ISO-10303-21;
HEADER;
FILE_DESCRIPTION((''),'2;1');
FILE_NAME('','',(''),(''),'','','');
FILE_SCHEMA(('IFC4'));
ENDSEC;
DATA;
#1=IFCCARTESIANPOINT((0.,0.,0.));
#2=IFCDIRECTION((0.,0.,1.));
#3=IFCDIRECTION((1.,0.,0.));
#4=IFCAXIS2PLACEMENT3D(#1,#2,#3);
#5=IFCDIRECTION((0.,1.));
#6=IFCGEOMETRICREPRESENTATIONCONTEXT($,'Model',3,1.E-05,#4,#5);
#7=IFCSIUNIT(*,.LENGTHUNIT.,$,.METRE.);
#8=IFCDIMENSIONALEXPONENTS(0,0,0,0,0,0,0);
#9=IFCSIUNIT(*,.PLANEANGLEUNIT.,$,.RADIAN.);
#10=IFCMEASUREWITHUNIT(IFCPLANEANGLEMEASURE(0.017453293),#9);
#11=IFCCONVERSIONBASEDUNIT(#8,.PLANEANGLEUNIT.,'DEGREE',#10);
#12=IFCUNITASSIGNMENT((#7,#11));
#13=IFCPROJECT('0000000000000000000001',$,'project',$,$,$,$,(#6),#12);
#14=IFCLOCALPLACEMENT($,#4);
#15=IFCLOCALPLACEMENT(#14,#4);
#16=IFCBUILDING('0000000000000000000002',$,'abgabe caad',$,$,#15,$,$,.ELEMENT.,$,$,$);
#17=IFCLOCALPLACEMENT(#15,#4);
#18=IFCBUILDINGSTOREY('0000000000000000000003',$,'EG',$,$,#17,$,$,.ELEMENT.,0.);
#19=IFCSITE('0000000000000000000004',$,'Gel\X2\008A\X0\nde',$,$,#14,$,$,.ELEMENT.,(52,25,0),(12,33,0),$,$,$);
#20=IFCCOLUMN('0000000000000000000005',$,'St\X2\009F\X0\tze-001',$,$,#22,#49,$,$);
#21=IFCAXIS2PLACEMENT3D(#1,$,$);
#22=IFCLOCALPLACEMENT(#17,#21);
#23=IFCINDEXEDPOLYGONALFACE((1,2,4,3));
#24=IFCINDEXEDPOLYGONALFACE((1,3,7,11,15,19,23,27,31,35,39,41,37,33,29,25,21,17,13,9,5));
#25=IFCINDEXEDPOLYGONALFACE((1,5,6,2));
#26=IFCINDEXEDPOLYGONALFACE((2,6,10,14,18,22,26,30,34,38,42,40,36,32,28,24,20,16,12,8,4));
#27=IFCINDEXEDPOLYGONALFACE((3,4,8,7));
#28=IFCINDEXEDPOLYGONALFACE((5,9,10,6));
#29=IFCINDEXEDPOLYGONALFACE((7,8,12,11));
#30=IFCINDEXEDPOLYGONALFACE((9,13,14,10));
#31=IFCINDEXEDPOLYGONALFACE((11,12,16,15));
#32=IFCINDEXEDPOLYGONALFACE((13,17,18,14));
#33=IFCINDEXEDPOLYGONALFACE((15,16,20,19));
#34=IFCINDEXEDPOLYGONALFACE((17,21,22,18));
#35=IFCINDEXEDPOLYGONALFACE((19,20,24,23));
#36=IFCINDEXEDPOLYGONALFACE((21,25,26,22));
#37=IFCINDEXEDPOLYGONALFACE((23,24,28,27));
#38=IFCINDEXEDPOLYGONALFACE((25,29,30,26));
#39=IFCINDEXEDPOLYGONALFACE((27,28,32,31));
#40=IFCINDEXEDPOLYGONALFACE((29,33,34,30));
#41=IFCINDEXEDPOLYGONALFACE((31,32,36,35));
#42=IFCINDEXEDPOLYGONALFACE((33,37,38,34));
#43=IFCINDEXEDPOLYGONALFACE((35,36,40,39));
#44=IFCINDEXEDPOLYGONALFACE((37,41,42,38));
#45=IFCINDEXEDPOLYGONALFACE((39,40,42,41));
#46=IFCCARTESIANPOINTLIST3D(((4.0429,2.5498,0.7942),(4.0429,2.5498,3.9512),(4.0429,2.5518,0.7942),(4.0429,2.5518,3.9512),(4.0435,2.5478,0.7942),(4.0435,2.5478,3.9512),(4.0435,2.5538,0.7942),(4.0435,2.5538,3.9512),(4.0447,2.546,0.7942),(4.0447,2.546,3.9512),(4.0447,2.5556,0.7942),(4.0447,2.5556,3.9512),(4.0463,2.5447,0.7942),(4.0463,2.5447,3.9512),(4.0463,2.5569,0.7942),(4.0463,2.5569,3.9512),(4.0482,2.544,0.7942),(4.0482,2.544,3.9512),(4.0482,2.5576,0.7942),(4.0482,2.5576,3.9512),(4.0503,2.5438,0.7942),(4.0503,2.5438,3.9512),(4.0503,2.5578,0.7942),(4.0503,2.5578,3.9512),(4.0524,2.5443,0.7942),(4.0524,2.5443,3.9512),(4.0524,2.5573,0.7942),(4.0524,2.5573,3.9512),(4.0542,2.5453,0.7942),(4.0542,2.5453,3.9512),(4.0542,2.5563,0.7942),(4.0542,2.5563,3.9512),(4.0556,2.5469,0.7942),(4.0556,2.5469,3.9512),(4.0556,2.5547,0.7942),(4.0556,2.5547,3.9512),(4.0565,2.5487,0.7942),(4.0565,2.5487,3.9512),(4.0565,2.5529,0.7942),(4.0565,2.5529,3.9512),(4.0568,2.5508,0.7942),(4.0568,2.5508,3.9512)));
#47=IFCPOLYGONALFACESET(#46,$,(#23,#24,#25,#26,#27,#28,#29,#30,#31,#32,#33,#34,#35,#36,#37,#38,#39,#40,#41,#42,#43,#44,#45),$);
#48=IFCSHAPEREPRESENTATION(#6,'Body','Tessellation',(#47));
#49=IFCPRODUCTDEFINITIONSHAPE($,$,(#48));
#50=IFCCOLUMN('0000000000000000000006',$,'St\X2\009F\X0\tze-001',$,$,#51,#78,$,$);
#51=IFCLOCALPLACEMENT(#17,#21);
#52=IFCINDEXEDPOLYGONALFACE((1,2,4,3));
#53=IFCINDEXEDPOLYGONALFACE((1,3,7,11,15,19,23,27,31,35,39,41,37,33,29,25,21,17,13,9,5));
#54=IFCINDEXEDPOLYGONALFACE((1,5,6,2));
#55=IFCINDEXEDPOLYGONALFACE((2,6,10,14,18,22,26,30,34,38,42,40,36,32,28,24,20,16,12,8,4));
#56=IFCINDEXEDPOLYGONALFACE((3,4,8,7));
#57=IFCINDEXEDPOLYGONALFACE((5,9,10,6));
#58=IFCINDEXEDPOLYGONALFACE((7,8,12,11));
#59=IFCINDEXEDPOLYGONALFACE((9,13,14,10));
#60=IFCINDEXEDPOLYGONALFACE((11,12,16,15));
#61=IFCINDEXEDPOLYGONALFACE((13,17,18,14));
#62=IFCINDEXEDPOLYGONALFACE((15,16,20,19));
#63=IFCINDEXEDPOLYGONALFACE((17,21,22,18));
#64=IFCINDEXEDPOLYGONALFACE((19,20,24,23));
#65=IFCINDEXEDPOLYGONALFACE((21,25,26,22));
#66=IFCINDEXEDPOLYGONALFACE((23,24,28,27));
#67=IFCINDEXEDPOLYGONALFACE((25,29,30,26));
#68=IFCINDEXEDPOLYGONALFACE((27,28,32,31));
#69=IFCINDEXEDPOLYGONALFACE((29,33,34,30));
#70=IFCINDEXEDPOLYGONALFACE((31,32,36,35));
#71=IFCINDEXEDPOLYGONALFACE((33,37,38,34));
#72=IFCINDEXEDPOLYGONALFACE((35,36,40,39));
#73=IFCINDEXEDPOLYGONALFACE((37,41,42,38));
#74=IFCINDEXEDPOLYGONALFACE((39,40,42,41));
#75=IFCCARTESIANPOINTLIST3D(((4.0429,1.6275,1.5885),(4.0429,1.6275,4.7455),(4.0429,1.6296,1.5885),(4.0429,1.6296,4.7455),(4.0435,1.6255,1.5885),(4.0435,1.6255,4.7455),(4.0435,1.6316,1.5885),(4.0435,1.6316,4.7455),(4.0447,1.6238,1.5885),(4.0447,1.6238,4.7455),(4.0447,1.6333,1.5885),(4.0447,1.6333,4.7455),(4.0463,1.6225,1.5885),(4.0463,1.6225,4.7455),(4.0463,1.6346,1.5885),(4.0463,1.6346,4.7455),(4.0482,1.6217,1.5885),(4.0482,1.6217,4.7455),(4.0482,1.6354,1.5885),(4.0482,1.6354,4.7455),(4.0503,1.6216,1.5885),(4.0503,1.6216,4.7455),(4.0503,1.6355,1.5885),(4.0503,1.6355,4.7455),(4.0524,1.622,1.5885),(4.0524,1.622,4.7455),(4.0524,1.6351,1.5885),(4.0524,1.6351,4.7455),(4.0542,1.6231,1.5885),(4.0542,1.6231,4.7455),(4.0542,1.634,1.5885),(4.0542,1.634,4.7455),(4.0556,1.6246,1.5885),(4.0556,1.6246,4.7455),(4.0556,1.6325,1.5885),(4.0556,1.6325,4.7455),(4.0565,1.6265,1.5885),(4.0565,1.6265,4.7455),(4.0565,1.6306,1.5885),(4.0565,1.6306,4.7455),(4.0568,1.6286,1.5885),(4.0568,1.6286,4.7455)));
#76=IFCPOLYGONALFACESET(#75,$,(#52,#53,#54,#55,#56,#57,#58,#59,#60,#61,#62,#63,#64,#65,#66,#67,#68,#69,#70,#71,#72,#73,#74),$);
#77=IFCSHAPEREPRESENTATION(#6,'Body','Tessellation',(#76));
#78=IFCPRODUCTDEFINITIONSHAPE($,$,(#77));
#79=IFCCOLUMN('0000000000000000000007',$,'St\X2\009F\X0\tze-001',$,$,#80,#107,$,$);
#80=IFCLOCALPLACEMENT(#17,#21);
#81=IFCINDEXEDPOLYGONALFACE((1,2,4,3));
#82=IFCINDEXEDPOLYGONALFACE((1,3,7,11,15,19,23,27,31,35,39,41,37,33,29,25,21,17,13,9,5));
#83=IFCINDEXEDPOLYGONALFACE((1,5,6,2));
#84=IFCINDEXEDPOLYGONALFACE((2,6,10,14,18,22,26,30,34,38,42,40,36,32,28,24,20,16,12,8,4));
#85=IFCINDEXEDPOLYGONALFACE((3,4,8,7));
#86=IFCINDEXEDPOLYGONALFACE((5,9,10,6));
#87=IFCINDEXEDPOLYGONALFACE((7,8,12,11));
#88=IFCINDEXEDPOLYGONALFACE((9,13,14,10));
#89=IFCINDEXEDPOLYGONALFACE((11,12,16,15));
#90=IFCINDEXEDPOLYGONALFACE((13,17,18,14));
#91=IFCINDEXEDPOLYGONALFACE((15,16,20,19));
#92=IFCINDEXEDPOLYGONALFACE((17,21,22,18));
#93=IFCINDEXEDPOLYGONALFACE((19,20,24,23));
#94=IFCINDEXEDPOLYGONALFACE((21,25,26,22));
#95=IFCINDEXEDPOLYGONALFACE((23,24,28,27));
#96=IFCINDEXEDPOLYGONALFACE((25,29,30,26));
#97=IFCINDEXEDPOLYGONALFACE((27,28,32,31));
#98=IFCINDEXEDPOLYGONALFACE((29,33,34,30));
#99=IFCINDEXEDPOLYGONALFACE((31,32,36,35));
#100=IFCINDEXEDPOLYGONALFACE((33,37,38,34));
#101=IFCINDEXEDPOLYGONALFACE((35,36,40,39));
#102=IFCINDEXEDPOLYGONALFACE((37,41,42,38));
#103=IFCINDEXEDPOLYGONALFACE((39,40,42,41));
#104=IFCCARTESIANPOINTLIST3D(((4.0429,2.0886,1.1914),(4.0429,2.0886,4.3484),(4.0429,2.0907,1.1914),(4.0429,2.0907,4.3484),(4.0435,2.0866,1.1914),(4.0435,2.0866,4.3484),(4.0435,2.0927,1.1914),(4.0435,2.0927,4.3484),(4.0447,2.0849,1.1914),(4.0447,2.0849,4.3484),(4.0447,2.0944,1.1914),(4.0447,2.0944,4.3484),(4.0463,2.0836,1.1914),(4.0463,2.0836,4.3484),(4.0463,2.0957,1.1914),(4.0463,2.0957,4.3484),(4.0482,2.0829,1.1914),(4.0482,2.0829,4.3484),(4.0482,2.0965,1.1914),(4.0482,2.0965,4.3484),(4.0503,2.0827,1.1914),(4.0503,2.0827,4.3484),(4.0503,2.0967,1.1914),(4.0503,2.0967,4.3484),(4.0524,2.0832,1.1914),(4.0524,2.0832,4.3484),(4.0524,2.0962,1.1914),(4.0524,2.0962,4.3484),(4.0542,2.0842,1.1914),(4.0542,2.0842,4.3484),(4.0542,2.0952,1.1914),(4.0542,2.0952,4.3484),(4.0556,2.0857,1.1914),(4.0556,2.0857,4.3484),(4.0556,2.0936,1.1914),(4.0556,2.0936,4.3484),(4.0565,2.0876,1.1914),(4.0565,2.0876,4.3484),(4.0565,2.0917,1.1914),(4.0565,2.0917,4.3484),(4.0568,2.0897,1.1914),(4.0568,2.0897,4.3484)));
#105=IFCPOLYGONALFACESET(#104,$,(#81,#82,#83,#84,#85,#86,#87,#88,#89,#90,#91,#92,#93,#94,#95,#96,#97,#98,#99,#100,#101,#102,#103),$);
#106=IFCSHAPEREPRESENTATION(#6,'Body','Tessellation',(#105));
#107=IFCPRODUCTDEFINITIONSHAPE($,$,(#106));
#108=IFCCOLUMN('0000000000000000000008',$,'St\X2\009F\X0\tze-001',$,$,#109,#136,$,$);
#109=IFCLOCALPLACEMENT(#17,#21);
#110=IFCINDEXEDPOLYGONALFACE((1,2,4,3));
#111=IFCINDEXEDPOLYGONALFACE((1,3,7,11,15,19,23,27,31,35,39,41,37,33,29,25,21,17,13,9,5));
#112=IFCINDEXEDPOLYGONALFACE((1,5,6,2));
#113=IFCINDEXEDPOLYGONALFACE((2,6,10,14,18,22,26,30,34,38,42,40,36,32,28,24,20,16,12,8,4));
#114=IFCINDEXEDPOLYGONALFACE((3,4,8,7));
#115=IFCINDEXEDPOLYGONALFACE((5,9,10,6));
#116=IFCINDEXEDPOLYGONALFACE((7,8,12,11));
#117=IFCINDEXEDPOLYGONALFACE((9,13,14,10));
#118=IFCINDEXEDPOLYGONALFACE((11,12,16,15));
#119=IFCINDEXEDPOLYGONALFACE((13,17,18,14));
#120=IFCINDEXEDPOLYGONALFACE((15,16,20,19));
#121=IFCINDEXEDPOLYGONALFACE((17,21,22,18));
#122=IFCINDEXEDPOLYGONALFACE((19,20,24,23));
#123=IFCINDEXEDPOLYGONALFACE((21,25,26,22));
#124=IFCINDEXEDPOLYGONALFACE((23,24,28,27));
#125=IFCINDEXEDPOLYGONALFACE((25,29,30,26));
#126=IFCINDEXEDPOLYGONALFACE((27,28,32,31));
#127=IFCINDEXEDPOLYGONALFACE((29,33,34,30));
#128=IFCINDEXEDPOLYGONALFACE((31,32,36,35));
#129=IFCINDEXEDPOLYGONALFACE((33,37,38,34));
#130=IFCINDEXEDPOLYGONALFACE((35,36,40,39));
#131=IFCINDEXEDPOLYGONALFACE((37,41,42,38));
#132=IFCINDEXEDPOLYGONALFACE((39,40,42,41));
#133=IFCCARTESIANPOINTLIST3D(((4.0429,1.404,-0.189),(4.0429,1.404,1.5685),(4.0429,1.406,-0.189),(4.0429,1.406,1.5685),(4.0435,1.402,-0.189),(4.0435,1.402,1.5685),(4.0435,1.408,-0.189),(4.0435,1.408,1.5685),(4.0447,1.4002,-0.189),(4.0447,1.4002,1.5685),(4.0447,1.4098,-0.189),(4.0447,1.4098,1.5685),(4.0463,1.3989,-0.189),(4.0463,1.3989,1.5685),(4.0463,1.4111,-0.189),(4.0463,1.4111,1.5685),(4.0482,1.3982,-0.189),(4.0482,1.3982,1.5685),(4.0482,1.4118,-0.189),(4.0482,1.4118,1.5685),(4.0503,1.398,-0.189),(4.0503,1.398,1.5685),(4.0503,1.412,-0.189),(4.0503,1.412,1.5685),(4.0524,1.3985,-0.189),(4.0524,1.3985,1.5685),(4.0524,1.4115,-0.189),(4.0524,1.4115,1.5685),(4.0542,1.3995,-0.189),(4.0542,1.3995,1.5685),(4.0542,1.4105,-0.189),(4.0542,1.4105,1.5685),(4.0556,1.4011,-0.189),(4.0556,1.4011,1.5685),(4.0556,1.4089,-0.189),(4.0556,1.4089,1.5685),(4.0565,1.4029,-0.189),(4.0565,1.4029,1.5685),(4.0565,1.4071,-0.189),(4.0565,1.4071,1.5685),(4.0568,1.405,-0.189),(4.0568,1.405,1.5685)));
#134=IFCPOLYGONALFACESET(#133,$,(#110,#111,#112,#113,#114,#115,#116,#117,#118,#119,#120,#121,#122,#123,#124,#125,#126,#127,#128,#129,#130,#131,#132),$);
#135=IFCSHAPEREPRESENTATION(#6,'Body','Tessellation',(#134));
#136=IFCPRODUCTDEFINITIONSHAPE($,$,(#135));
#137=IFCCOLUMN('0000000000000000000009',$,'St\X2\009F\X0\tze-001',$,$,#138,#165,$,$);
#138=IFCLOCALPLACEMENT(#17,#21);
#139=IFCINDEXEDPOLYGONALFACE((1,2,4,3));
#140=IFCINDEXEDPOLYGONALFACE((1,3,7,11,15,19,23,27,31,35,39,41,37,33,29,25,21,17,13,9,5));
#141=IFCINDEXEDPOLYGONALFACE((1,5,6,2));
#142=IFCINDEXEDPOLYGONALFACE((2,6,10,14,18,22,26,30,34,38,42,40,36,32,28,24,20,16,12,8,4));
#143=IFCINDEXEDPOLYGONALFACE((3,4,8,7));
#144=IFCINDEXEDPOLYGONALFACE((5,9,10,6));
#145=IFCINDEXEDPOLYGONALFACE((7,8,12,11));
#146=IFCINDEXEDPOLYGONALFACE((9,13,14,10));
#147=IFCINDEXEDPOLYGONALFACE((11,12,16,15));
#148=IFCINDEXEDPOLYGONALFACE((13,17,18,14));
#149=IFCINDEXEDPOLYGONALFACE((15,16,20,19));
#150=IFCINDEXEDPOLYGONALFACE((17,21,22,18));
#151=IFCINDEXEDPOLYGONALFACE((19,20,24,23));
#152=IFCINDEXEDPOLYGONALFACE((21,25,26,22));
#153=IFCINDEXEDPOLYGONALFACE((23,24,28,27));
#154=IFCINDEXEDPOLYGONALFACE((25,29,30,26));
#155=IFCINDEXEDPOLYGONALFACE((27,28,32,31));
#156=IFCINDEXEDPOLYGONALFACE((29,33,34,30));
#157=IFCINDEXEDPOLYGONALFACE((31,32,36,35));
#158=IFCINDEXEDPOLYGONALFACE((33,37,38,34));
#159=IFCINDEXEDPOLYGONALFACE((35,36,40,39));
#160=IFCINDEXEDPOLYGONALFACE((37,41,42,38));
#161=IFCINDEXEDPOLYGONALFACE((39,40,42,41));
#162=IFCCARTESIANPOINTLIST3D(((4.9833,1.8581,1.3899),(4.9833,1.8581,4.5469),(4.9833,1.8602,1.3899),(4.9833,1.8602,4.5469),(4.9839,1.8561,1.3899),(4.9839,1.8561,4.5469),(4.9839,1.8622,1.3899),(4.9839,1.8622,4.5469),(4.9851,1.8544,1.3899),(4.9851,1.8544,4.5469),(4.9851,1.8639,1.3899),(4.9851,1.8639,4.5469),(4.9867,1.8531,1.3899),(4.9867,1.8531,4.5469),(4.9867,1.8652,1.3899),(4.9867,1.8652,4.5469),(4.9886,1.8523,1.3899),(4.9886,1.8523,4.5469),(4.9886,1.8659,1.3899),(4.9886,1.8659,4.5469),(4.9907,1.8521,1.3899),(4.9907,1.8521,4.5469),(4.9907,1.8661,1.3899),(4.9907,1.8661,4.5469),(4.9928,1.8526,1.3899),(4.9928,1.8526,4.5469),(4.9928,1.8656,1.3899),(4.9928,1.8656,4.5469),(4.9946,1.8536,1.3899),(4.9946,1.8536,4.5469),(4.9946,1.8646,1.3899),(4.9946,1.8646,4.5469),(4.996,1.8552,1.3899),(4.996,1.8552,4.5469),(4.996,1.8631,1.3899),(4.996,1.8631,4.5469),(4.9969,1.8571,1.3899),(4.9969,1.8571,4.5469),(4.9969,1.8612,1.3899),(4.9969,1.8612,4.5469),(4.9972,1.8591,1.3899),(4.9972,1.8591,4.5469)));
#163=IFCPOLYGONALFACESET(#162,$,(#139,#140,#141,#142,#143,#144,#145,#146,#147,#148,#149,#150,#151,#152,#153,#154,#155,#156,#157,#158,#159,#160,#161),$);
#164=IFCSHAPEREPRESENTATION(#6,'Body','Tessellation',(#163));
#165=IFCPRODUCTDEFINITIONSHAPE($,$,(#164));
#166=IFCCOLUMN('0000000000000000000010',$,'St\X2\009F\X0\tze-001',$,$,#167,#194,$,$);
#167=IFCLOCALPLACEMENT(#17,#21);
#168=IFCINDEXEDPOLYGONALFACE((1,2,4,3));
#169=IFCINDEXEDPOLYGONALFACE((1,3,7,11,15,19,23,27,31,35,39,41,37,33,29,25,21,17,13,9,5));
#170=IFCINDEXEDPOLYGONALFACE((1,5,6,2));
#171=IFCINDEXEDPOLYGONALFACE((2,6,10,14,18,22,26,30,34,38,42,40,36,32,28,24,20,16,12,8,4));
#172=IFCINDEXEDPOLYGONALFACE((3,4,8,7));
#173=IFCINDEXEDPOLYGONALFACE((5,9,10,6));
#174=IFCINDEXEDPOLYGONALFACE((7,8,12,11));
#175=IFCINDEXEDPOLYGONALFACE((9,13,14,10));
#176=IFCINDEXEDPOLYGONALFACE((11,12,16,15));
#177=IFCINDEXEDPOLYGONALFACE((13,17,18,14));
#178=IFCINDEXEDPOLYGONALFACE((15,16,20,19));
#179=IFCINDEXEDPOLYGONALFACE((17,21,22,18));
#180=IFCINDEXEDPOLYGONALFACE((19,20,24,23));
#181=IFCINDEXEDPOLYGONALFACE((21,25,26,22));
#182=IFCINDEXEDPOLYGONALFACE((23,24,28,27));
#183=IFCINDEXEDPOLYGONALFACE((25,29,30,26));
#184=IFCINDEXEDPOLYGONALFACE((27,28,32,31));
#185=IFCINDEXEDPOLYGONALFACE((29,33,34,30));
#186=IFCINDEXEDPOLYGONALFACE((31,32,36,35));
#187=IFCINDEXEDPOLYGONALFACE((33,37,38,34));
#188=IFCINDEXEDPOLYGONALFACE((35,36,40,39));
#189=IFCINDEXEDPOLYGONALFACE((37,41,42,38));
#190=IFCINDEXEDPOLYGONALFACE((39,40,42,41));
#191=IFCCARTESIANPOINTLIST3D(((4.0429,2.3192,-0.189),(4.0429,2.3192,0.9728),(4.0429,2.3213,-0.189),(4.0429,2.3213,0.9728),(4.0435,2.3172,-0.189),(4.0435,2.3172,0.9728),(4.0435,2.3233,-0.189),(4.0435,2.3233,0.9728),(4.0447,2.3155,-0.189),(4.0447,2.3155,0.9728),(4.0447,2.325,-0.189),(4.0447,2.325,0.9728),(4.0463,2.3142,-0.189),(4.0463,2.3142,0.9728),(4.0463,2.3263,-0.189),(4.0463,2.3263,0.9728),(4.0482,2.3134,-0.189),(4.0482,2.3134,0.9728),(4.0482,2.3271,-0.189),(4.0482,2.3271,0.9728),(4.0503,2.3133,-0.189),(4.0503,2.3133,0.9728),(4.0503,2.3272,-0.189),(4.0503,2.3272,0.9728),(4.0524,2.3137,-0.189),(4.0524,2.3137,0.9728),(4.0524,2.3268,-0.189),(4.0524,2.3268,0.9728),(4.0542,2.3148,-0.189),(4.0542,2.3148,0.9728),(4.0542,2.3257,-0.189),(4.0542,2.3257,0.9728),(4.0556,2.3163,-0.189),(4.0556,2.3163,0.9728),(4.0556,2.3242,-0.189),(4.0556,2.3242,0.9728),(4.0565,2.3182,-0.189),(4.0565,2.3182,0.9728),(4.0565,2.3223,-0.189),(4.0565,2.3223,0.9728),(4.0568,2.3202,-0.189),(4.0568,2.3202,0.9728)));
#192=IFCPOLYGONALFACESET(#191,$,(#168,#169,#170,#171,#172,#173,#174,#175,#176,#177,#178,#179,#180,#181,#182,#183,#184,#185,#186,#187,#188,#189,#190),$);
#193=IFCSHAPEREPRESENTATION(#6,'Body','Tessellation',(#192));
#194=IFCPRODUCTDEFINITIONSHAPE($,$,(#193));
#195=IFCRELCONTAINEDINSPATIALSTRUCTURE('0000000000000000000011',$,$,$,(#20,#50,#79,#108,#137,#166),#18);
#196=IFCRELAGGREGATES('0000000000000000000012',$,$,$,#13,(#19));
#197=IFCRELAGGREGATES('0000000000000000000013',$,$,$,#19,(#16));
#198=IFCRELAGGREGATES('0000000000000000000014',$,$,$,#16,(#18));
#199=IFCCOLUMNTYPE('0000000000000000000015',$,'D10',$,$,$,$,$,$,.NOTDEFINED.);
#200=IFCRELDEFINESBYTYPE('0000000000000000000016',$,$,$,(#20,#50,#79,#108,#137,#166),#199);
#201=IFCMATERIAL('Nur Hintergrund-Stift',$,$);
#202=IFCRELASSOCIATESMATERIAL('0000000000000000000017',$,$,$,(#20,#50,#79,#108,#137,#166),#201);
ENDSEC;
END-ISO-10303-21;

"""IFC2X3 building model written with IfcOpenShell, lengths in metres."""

from ifc_helpers import new_model, entity, si_unit, converted_unit, direction, frame, origin_with_axes, origin_2d_with_axis, place, context, project, spatial, circle, extrude, material, type_object, element, save


model = new_model("IFC2X3")

# Units and contexts
model_context = context("Model", 3, precision=1e-05, world=origin_with_axes(), true_north=direction((0.0, 1.0)))
ifc_project = project(units=[si_unit("LENGTHUNIT", "METRE"), converted_unit("PLANEANGLEUNIT", "DEGREE", entity("IfcPlaneAngleMeasure", 0.017453293), si_unit("PLANEANGLEUNIT", "RADIAN"), dimensions=[0, 0, 0, 0, 0, 0, 0])], contexts=[model_context])

# Site, building, storey
site_placement = place(None, origin_with_axes())
site = spatial("IfcSite", under=ifc_project, at=site_placement, Name="Gel\u008ande", CompositionType="ELEMENT", RefLatitude=(52, 25, 0), RefLongitude=(12, 33, 0))
building_placement = place(site_placement, origin_with_axes())
building = spatial("IfcBuilding", under=site, at=building_placement, Name="abgabe caad", CompositionType="ELEMENT")
storey_placement = place(building_placement, origin_with_axes())
storey = spatial("IfcBuildingStorey", under=building, at=storey_placement, Name="EG", CompositionType="ELEMENT", Elevation=0.0)

# Columns
ifc_material_1 = material(Name="Nur Hintergrund-Stift")
column_type = type_object("IfcColumnType", Name="D10", PredefinedType="NOTDEFINED")
for number, where, z_axis, x_axis, name in (
    (1, (4.0498, 2.5508, 0.7943), (0.0, 0.0, 1.0), (1.0, 0.0, 0.0), "St\u009ftze-001"),
    (2, (4.0498, 1.6286, 1.5885), (0.0, 0.0, 1.0), (1.0, 0.0, 0.0), "St\u009ftze-001"),
    (3, (4.0498, 2.0897, 1.1914), (0.0, 0.0, 1.0), (1.0, 0.0, 0.0), "St\u009ftze-001"),
):
    element("IfcColumn", number, at=place(storey_placement, frame(where, z_axis=z_axis, x_axis=x_axis)), inside=storey, type_object=column_type, material=ifc_material_1, Name=name, context=model_context, shape_type="SweptSolid", body=[
        extrude(circle(Radius=0.007, at=origin_2d_with_axis()), origin_with_axes(), (0.0, 0.0, 1.0), 3.157),
    ])
column_1_placement = place(storey_placement, frame((4.0498, 1.405, -0.189), z_axis=(0.0, 0.0, 1.0), x_axis=(1.0, 0.0, 0.0)))
element("IfcColumn", 4, at=column_1_placement, inside=storey, type_object=column_type, material=ifc_material_1, Name="St\u009ftze-001", context=model_context, shape_type="SweptSolid", body=[
    extrude(circle(Radius=0.007, at=origin_2d_with_axis()), origin_with_axes(), (0.0, 0.0, 1.0), 1.7575),
])
column_2_placement = place(storey_placement, frame((4.9902, 1.8591, 1.3899), z_axis=(0.0, 0.0, 1.0), x_axis=(1.0, 0.0, 0.0)))
element("IfcColumn", 5, at=column_2_placement, inside=storey, type_object=column_type, material=ifc_material_1, Name="St\u009ftze-001", context=model_context, shape_type="SweptSolid", body=[
    extrude(circle(Radius=0.007, at=origin_2d_with_axis()), origin_with_axes(), (0.0, 0.0, 1.0), 3.157),
])
column_3_placement = place(storey_placement, frame((4.0498, 2.3202, -0.189), z_axis=(0.0, 0.0, 1.0), x_axis=(1.0, 0.0, 0.0)))
element("IfcColumn", 6, at=column_3_placement, inside=storey, type_object=column_type, material=ifc_material_1, Name="St\u009ftze-001", context=model_context, shape_type="SweptSolid", body=[
    extrude(circle(Radius=0.007, at=origin_2d_with_axis()), origin_with_axes(), (0.0, 0.0, 1.0), 1.1618),
])

save(model, "model.ifc")
